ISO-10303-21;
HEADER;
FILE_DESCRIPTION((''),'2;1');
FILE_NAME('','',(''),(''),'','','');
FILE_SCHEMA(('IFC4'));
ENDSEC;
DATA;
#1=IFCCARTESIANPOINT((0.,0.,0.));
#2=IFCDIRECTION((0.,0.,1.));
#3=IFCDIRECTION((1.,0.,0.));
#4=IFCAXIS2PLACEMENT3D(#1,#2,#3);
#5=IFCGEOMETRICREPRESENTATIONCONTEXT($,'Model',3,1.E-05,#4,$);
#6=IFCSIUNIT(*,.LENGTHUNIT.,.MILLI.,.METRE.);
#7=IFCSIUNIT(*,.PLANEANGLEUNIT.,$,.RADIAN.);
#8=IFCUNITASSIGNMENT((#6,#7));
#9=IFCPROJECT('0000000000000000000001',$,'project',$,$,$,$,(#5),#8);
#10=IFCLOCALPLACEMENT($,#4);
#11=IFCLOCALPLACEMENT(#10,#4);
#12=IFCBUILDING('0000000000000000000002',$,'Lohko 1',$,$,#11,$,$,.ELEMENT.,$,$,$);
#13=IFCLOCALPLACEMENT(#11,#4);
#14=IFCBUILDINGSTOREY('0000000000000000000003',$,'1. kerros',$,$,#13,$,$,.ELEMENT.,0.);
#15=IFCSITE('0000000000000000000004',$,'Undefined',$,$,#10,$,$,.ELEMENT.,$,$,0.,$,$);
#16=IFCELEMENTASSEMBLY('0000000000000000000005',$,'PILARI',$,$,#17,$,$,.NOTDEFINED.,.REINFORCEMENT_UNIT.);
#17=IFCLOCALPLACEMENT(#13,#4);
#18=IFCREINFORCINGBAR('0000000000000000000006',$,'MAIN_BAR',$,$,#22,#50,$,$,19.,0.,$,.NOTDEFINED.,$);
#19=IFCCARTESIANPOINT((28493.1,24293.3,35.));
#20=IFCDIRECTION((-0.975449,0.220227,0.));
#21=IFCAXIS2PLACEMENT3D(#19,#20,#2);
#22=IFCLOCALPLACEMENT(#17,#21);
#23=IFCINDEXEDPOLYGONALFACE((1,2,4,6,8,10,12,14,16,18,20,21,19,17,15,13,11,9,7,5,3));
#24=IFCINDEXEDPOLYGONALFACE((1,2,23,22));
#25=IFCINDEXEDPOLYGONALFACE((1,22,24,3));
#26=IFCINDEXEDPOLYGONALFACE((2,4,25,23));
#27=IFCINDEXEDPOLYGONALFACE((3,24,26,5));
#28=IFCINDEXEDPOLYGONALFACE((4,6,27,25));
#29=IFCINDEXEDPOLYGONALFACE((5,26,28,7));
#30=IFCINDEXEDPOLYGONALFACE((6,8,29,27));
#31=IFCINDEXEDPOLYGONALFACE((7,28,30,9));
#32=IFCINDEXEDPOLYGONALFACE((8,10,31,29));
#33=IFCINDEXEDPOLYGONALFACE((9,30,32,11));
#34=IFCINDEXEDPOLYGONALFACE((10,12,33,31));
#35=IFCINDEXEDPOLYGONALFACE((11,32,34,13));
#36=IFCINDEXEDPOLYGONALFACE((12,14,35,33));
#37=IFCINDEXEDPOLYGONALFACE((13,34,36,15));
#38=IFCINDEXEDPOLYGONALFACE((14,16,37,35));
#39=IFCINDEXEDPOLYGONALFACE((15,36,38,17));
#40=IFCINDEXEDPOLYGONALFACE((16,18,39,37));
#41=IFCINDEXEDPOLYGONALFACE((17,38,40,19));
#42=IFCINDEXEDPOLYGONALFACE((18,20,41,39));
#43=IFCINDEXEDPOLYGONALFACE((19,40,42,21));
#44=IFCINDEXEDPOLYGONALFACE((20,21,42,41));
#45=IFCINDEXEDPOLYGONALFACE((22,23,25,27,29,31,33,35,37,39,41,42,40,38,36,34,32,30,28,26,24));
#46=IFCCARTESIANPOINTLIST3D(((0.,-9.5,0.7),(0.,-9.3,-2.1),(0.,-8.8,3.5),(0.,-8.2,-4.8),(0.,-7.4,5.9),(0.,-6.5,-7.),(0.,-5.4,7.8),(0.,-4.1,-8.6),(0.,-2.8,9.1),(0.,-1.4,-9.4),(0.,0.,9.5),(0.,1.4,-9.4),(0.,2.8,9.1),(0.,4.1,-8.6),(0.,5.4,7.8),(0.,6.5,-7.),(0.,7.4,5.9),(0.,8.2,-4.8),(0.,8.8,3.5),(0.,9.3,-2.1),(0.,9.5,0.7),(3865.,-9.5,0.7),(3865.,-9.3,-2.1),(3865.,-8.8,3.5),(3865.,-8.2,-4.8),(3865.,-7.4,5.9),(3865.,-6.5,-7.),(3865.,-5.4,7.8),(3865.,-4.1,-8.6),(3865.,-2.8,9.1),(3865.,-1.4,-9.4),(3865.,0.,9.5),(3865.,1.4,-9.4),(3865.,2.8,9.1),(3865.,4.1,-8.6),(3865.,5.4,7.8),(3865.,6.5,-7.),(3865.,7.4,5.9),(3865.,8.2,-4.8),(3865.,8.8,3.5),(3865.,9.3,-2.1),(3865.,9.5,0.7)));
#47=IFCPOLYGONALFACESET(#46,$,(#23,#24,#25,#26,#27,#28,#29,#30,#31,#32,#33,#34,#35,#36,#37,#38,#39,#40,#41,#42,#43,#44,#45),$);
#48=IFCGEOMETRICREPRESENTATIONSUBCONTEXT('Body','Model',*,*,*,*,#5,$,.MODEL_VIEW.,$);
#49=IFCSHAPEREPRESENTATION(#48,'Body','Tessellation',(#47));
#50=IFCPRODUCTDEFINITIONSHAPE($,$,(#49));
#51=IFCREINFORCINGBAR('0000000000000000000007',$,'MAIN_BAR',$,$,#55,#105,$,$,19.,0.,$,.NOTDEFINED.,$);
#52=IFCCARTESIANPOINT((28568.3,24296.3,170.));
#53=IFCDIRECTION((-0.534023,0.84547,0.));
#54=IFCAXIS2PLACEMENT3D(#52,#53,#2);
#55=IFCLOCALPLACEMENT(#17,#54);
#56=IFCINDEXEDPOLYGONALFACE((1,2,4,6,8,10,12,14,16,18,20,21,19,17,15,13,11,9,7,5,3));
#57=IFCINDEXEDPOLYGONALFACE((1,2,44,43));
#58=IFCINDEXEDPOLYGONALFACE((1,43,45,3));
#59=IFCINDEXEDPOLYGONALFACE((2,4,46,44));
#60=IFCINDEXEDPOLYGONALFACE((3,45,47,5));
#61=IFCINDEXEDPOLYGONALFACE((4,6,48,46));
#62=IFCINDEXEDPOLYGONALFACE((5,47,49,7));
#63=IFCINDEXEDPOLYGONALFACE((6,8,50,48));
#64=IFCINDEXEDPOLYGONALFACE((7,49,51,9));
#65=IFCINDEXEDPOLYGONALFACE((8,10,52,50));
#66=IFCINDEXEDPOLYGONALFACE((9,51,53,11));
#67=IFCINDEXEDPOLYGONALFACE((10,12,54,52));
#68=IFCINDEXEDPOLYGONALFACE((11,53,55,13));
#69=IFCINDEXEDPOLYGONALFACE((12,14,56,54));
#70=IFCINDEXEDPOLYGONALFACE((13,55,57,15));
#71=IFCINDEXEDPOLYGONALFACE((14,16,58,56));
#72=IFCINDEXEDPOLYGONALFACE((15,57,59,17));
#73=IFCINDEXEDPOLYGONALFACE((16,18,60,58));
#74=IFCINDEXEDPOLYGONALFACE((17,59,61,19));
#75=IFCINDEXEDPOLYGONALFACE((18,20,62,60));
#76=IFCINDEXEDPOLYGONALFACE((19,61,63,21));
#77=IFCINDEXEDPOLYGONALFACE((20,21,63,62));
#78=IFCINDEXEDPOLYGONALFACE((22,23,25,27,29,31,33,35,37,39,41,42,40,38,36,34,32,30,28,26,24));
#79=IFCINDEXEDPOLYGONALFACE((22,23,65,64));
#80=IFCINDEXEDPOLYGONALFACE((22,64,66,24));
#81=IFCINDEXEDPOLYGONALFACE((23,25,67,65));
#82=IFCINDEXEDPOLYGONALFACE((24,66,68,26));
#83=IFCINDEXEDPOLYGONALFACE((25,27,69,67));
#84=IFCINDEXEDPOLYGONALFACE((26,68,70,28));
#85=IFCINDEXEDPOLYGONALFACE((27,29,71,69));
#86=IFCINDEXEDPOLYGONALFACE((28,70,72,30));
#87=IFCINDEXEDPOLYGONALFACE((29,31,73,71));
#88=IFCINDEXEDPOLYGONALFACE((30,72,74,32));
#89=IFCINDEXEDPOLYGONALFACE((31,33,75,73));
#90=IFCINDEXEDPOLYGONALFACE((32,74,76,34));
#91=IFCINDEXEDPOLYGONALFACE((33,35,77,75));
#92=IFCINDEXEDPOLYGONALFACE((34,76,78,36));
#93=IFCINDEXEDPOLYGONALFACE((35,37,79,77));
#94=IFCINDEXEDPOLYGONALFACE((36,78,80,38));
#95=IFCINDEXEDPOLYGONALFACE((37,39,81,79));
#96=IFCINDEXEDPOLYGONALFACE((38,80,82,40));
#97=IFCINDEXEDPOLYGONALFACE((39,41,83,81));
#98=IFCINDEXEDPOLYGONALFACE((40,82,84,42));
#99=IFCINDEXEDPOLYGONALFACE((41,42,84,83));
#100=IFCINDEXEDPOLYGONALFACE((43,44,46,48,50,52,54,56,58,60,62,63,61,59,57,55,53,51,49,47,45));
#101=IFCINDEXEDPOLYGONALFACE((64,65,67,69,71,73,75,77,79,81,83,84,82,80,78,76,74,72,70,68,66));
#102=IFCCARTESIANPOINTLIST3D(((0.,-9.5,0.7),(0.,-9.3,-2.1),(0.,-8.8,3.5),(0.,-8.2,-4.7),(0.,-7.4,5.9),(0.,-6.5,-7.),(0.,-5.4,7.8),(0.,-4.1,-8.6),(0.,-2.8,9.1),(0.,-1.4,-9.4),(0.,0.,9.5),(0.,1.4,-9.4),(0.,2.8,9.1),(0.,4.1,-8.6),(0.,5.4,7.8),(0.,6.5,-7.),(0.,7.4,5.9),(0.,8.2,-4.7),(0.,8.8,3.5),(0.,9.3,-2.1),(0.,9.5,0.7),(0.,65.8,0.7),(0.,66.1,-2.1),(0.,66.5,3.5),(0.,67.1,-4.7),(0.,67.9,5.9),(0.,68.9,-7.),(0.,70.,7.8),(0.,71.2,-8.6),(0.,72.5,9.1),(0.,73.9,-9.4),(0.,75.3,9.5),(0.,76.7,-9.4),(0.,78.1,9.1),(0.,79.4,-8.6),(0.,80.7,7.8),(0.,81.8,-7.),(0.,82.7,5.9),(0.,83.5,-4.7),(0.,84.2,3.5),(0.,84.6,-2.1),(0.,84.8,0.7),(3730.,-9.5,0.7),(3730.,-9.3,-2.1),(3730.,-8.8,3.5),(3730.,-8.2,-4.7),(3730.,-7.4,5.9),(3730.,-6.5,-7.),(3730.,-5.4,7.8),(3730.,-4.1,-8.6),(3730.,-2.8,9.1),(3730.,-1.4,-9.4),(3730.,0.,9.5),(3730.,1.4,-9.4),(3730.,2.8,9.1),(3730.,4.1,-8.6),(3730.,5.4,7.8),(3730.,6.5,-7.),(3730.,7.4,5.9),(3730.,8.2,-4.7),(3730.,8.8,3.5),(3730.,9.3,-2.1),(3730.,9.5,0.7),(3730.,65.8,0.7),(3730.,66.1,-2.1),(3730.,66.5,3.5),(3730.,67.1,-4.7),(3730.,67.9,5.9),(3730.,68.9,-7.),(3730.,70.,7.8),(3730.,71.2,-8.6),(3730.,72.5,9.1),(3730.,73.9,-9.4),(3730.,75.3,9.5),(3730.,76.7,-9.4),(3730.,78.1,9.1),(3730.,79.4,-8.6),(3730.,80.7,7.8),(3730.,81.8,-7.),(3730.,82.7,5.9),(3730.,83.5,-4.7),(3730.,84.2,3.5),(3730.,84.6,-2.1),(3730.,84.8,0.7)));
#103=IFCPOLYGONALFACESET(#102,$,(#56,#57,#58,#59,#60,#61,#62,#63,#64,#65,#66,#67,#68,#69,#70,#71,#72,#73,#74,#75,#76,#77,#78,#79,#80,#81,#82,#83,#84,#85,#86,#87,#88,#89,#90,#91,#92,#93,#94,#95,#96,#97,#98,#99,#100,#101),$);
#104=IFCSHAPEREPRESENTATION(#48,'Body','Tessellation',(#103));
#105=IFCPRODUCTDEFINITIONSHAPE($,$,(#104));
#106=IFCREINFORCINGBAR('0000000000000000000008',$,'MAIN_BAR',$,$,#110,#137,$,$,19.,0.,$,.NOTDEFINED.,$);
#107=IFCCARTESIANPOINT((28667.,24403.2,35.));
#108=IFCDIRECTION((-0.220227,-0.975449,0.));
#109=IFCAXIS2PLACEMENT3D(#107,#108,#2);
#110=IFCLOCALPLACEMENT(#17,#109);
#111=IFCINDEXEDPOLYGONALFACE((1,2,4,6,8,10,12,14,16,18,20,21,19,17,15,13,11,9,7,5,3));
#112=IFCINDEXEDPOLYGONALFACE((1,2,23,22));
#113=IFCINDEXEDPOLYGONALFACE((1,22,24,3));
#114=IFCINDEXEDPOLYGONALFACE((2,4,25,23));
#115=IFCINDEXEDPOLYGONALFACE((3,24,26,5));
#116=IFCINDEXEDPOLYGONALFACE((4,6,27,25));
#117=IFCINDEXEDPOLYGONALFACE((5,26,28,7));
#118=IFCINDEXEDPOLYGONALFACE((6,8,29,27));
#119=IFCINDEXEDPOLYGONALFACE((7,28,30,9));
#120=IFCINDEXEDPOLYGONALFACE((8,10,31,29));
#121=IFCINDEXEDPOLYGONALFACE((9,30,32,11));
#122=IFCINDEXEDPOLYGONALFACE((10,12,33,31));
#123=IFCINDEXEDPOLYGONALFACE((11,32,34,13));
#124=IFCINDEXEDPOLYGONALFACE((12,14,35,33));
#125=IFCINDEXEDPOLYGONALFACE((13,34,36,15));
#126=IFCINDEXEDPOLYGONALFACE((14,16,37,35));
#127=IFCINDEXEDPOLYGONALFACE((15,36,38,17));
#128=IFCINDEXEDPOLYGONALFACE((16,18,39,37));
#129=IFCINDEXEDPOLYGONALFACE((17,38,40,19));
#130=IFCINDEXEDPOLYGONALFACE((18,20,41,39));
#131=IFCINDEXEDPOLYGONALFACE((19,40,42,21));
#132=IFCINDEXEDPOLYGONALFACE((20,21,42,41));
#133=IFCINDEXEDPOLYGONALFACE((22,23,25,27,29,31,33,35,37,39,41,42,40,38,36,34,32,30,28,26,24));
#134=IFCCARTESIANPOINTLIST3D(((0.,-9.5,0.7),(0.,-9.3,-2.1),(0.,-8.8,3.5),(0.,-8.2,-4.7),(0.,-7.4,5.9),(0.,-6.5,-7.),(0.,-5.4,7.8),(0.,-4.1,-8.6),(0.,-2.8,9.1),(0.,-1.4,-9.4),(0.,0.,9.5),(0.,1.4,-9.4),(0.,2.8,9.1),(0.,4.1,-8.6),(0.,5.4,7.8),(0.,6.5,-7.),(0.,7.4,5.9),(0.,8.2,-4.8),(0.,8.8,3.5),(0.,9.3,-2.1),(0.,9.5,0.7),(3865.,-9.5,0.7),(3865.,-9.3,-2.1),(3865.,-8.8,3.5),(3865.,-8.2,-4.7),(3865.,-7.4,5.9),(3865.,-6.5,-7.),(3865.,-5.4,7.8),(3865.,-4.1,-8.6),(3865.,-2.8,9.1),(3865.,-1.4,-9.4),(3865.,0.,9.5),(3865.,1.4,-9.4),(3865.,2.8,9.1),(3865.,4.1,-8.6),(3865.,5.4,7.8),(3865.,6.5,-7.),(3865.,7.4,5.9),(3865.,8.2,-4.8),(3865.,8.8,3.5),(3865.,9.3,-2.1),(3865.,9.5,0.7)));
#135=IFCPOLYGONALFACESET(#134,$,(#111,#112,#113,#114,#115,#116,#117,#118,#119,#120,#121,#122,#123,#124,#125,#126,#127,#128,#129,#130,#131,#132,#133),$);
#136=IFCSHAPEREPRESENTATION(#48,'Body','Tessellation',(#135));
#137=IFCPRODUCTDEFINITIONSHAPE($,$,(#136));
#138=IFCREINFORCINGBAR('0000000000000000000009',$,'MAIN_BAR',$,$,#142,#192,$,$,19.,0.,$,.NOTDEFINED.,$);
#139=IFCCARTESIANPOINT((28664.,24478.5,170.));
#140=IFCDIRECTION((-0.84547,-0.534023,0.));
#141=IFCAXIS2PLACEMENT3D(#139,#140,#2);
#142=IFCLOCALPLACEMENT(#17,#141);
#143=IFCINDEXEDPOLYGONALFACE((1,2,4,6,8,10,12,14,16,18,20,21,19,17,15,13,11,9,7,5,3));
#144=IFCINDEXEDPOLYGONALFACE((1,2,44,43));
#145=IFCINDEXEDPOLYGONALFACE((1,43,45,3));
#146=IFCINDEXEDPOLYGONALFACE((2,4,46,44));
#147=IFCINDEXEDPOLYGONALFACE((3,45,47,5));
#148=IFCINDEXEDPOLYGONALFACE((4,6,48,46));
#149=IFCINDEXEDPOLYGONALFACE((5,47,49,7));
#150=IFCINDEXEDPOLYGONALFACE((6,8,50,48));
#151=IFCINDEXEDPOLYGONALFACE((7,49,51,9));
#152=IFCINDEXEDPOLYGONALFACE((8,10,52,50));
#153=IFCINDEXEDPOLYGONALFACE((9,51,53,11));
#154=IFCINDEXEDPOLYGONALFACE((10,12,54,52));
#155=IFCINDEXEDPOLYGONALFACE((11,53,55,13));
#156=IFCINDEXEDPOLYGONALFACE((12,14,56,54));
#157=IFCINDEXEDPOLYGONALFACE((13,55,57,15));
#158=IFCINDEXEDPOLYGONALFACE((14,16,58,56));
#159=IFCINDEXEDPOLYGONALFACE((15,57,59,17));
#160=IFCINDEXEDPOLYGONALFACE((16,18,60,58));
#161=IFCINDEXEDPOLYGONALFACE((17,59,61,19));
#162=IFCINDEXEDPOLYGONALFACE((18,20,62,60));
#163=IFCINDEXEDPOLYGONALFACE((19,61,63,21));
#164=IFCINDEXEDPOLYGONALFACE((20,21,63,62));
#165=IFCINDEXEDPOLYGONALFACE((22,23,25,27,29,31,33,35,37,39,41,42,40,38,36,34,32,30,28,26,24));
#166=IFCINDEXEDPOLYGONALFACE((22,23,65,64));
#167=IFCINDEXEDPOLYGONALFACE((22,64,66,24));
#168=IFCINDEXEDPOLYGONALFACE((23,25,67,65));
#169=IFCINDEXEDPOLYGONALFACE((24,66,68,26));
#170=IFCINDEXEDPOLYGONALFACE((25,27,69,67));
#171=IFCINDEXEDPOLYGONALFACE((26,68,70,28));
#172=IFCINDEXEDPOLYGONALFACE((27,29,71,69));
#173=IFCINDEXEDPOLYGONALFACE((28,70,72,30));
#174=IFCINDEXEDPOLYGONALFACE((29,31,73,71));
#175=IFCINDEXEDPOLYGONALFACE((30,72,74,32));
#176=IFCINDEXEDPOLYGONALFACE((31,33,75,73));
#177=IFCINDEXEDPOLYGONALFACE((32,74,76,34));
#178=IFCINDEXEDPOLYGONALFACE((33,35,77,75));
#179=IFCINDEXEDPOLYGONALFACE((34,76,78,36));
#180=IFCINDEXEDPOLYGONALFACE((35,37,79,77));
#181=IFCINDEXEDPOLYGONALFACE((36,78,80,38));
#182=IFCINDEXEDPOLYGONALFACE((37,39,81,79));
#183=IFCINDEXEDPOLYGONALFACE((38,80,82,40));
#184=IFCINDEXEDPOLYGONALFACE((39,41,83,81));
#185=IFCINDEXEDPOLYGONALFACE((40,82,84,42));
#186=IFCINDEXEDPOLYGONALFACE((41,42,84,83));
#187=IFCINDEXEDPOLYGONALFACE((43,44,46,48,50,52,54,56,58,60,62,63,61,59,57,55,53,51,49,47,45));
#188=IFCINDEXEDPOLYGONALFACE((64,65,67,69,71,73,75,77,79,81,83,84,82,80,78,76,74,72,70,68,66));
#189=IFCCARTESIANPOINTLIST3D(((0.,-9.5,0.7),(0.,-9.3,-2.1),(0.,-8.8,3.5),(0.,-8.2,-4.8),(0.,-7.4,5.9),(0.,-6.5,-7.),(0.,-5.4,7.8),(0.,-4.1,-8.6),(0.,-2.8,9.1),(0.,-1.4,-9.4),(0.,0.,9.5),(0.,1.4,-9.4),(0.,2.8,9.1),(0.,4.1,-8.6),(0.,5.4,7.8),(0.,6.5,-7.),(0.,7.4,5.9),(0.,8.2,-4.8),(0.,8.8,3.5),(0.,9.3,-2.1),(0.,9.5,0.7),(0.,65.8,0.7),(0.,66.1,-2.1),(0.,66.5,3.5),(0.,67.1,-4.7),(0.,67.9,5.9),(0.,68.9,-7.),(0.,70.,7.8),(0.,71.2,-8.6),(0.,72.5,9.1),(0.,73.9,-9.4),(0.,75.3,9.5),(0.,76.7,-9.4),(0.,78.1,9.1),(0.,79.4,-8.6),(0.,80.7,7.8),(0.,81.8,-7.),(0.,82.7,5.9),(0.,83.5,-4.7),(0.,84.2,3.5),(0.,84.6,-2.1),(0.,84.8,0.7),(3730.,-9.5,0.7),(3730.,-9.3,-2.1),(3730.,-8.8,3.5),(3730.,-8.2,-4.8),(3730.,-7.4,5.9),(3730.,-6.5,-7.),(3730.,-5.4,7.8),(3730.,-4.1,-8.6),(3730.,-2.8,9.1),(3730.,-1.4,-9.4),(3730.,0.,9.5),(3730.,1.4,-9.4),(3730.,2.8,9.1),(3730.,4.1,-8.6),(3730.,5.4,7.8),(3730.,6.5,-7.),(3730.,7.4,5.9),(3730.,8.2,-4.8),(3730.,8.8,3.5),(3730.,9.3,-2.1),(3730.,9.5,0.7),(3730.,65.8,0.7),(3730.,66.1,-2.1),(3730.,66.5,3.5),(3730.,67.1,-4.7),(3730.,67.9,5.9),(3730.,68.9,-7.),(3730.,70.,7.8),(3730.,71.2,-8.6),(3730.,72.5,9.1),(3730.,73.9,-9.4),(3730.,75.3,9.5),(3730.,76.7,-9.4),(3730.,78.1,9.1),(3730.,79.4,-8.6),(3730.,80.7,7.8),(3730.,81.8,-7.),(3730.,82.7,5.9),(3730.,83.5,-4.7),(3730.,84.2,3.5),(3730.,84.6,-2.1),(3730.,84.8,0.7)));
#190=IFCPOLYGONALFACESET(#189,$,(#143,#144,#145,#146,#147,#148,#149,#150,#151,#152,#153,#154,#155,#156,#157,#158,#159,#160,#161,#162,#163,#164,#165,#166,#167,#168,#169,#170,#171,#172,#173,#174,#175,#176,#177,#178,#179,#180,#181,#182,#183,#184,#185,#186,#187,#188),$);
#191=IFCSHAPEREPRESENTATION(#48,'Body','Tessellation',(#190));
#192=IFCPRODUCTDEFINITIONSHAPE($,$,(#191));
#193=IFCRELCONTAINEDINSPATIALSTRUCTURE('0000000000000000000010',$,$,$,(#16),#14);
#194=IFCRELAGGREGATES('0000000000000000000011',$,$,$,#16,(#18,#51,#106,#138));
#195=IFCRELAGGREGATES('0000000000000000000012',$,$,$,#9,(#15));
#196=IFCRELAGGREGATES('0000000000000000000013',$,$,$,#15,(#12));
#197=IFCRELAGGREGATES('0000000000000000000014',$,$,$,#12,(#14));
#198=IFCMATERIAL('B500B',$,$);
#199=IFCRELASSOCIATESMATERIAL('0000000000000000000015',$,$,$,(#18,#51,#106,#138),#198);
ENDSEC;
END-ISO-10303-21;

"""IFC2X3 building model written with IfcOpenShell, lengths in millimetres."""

from ifc_helpers import new_model, entity, si_unit, frame, origin_with_axes, place, context, subcontext, project, spatial, source, transform, mapped, material, element, aggregate, save


model = new_model("IFC2X3")

# Units and contexts
model_context = context("Model", 3, precision=1e-05, world=origin_with_axes())
body_context = subcontext(model_context, "Body", "Model", "MODEL_VIEW")
ifc_project = project(units=[si_unit("LENGTHUNIT", "METRE", prefix="MILLI"), si_unit("PLANEANGLEUNIT", "RADIAN")], contexts=[model_context])

# Site, building, storey
site_placement = place(None, origin_with_axes())
site = spatial("IfcSite", under=ifc_project, at=site_placement, Name="Undefined", CompositionType="ELEMENT", RefElevation=0.0)
building_placement = place(site_placement, origin_with_axes())
building = spatial("IfcBuilding", under=site, at=building_placement, Name="Lohko 1", CompositionType="ELEMENT")
storey_placement = place(building_placement, origin_with_axes())
storey = spatial("IfcBuildingStorey", under=building, at=storey_placement, Name="1. kerros", CompositionType="ELEMENT", Elevation=0.0)

# Element assembly, reinforcing bars
assembly_placement = place(storey_placement, origin_with_axes())
assembly = element("IfcElementAssembly", 1, at=assembly_placement, inside=storey, Name="PILARI", AssemblyPlace="NOTDEFINED", PredefinedType="REINFORCEMENT_UNIT")
ifc_material = material(Name="B500B")
shared_shape_1 = source(origin_with_axes(), body_context, "Body", "AdvancedSweptSolid", [
    entity("IfcSweptDiskSolid", entity("IfcTrimmedCurve", entity("IfcLine", entity("IfcCartesianPoint", [0.0, 0.0, 0.0]), entity("IfcVector", entity("IfcDirection", [1.0, 0.0, 0.0]), 1.0)), [entity("IfcParameterValue", 0.0)], [entity("IfcParameterValue", 3865.0)], True, "PARAMETER"), 9.5, None, 0.0, 3865.0),
])
reinforcing_bar_1_placement = place(assembly_placement, frame((28493.1, 24293.3, 35.0), z_axis=(-0.975449, 0.220227, 0.0), x_axis=(0.0, 0.0, 1.0)))
reinforcing_bar_1 = element("IfcReinforcingBar", 2, at=reinforcing_bar_1_placement, material=ifc_material, Name="MAIN_BAR", BarRole="NOTDEFINED", CrossSectionArea=0.0, NominalDiameter=19.0, context=body_context, shape_type="MappedRepresentation", body=[
    mapped(shared_shape_1, transform((0.0, 0.0, 0.0))),
])
shared_shape_2 = source(origin_with_axes(), body_context, "Body", "AdvancedSweptSolid", [
    entity("IfcSweptDiskSolid", entity("IfcTrimmedCurve", entity("IfcLine", entity("IfcCartesianPoint", [0.0, 0.0, 0.0]), entity("IfcVector", entity("IfcDirection", [1.0, 0.0, 0.0]), 1.0)), [entity("IfcParameterValue", 0.0)], [entity("IfcParameterValue", 3730.0)], True, "PARAMETER"), 9.5, None, 0.0, 3730.0),
])
shared_shape_3 = source(origin_with_axes(), body_context, "Body", "AdvancedSweptSolid", [
    entity("IfcSweptDiskSolid", entity("IfcTrimmedCurve", entity("IfcLine", entity("IfcCartesianPoint", [0.0, 0.0, 0.0]), entity("IfcVector", entity("IfcDirection", [1.0, 0.0, 0.0]), 1.0)), [entity("IfcParameterValue", 0.0)], [entity("IfcParameterValue", 3730.0)], True, "PARAMETER"), 9.5, None, 0.0, 3730.0),
])
reinforcing_bar_2_placement = place(assembly_placement, frame((28568.3, 24296.3, 170.0), z_axis=(-0.534023, 0.84547, 0.0), x_axis=(0.0, 0.0, 1.0)))
reinforcing_bar_2 = element("IfcReinforcingBar", 3, at=reinforcing_bar_2_placement, material=ifc_material, Name="MAIN_BAR", BarRole="NOTDEFINED", CrossSectionArea=0.0, NominalDiameter=19.0, context=body_context, shape_type="MappedRepresentation", body=[
    mapped(shared_shape_2, transform((0.0, 0.0, 0.0))),
    mapped(shared_shape_3, transform((0.0, 75.3, 0.0))),
])
shared_shape_4 = source(origin_with_axes(), body_context, "Body", "AdvancedSweptSolid", [
    entity("IfcSweptDiskSolid", entity("IfcTrimmedCurve", entity("IfcLine", entity("IfcCartesianPoint", [0.0, 0.0, 0.0]), entity("IfcVector", entity("IfcDirection", [1.0, 0.0, 0.0]), 1.0)), [entity("IfcParameterValue", 0.0)], [entity("IfcParameterValue", 3865.0)], True, "PARAMETER"), 9.5, None, 0.0, 3865.0),
])
reinforcing_bar_3_placement = place(assembly_placement, frame((28667.0, 24403.2, 35.0), z_axis=(-0.220227, -0.975449, 0.0), x_axis=(0.0, 0.0, 1.0)))
reinforcing_bar_3 = element("IfcReinforcingBar", 4, at=reinforcing_bar_3_placement, material=ifc_material, Name="MAIN_BAR", BarRole="NOTDEFINED", CrossSectionArea=0.0, NominalDiameter=19.0, context=body_context, shape_type="MappedRepresentation", body=[
    mapped(shared_shape_4, transform((0.0, 0.0, 0.0))),
])
shared_shape_5 = source(origin_with_axes(), body_context, "Body", "AdvancedSweptSolid", [
    entity("IfcSweptDiskSolid", entity("IfcTrimmedCurve", entity("IfcLine", entity("IfcCartesianPoint", [0.0, 0.0, 0.0]), entity("IfcVector", entity("IfcDirection", [1.0, 0.0, 0.0]), 1.0)), [entity("IfcParameterValue", 0.0)], [entity("IfcParameterValue", 3730.0)], True, "PARAMETER"), 9.5, None, 0.0, 3730.0),
])
shared_shape_6 = source(origin_with_axes(), body_context, "Body", "AdvancedSweptSolid", [
    entity("IfcSweptDiskSolid", entity("IfcTrimmedCurve", entity("IfcLine", entity("IfcCartesianPoint", [0.0, 0.0, 0.0]), entity("IfcVector", entity("IfcDirection", [1.0, 0.0, 0.0]), 1.0)), [entity("IfcParameterValue", 0.0)], [entity("IfcParameterValue", 3730.0)], True, "PARAMETER"), 9.5, None, 0.0, 3730.0),
])
reinforcing_bar_4_placement = place(assembly_placement, frame((28664.0, 24478.5, 170.0), z_axis=(-0.84547, -0.534023, 0.0), x_axis=(0.0, 0.0, 1.0)))
reinforcing_bar_4 = element("IfcReinforcingBar", 5, at=reinforcing_bar_4_placement, material=ifc_material, Name="MAIN_BAR", BarRole="NOTDEFINED", CrossSectionArea=0.0, NominalDiameter=19.0, context=body_context, shape_type="MappedRepresentation", body=[
    mapped(shared_shape_5, transform((0.0, 0.0, 0.0))),
    mapped(shared_shape_6, transform((0.0, 75.3, 0.0))),
])
aggregate(assembly, [reinforcing_bar_1, reinforcing_bar_2, reinforcing_bar_3, reinforcing_bar_4])

save(model, "model.ifc")
